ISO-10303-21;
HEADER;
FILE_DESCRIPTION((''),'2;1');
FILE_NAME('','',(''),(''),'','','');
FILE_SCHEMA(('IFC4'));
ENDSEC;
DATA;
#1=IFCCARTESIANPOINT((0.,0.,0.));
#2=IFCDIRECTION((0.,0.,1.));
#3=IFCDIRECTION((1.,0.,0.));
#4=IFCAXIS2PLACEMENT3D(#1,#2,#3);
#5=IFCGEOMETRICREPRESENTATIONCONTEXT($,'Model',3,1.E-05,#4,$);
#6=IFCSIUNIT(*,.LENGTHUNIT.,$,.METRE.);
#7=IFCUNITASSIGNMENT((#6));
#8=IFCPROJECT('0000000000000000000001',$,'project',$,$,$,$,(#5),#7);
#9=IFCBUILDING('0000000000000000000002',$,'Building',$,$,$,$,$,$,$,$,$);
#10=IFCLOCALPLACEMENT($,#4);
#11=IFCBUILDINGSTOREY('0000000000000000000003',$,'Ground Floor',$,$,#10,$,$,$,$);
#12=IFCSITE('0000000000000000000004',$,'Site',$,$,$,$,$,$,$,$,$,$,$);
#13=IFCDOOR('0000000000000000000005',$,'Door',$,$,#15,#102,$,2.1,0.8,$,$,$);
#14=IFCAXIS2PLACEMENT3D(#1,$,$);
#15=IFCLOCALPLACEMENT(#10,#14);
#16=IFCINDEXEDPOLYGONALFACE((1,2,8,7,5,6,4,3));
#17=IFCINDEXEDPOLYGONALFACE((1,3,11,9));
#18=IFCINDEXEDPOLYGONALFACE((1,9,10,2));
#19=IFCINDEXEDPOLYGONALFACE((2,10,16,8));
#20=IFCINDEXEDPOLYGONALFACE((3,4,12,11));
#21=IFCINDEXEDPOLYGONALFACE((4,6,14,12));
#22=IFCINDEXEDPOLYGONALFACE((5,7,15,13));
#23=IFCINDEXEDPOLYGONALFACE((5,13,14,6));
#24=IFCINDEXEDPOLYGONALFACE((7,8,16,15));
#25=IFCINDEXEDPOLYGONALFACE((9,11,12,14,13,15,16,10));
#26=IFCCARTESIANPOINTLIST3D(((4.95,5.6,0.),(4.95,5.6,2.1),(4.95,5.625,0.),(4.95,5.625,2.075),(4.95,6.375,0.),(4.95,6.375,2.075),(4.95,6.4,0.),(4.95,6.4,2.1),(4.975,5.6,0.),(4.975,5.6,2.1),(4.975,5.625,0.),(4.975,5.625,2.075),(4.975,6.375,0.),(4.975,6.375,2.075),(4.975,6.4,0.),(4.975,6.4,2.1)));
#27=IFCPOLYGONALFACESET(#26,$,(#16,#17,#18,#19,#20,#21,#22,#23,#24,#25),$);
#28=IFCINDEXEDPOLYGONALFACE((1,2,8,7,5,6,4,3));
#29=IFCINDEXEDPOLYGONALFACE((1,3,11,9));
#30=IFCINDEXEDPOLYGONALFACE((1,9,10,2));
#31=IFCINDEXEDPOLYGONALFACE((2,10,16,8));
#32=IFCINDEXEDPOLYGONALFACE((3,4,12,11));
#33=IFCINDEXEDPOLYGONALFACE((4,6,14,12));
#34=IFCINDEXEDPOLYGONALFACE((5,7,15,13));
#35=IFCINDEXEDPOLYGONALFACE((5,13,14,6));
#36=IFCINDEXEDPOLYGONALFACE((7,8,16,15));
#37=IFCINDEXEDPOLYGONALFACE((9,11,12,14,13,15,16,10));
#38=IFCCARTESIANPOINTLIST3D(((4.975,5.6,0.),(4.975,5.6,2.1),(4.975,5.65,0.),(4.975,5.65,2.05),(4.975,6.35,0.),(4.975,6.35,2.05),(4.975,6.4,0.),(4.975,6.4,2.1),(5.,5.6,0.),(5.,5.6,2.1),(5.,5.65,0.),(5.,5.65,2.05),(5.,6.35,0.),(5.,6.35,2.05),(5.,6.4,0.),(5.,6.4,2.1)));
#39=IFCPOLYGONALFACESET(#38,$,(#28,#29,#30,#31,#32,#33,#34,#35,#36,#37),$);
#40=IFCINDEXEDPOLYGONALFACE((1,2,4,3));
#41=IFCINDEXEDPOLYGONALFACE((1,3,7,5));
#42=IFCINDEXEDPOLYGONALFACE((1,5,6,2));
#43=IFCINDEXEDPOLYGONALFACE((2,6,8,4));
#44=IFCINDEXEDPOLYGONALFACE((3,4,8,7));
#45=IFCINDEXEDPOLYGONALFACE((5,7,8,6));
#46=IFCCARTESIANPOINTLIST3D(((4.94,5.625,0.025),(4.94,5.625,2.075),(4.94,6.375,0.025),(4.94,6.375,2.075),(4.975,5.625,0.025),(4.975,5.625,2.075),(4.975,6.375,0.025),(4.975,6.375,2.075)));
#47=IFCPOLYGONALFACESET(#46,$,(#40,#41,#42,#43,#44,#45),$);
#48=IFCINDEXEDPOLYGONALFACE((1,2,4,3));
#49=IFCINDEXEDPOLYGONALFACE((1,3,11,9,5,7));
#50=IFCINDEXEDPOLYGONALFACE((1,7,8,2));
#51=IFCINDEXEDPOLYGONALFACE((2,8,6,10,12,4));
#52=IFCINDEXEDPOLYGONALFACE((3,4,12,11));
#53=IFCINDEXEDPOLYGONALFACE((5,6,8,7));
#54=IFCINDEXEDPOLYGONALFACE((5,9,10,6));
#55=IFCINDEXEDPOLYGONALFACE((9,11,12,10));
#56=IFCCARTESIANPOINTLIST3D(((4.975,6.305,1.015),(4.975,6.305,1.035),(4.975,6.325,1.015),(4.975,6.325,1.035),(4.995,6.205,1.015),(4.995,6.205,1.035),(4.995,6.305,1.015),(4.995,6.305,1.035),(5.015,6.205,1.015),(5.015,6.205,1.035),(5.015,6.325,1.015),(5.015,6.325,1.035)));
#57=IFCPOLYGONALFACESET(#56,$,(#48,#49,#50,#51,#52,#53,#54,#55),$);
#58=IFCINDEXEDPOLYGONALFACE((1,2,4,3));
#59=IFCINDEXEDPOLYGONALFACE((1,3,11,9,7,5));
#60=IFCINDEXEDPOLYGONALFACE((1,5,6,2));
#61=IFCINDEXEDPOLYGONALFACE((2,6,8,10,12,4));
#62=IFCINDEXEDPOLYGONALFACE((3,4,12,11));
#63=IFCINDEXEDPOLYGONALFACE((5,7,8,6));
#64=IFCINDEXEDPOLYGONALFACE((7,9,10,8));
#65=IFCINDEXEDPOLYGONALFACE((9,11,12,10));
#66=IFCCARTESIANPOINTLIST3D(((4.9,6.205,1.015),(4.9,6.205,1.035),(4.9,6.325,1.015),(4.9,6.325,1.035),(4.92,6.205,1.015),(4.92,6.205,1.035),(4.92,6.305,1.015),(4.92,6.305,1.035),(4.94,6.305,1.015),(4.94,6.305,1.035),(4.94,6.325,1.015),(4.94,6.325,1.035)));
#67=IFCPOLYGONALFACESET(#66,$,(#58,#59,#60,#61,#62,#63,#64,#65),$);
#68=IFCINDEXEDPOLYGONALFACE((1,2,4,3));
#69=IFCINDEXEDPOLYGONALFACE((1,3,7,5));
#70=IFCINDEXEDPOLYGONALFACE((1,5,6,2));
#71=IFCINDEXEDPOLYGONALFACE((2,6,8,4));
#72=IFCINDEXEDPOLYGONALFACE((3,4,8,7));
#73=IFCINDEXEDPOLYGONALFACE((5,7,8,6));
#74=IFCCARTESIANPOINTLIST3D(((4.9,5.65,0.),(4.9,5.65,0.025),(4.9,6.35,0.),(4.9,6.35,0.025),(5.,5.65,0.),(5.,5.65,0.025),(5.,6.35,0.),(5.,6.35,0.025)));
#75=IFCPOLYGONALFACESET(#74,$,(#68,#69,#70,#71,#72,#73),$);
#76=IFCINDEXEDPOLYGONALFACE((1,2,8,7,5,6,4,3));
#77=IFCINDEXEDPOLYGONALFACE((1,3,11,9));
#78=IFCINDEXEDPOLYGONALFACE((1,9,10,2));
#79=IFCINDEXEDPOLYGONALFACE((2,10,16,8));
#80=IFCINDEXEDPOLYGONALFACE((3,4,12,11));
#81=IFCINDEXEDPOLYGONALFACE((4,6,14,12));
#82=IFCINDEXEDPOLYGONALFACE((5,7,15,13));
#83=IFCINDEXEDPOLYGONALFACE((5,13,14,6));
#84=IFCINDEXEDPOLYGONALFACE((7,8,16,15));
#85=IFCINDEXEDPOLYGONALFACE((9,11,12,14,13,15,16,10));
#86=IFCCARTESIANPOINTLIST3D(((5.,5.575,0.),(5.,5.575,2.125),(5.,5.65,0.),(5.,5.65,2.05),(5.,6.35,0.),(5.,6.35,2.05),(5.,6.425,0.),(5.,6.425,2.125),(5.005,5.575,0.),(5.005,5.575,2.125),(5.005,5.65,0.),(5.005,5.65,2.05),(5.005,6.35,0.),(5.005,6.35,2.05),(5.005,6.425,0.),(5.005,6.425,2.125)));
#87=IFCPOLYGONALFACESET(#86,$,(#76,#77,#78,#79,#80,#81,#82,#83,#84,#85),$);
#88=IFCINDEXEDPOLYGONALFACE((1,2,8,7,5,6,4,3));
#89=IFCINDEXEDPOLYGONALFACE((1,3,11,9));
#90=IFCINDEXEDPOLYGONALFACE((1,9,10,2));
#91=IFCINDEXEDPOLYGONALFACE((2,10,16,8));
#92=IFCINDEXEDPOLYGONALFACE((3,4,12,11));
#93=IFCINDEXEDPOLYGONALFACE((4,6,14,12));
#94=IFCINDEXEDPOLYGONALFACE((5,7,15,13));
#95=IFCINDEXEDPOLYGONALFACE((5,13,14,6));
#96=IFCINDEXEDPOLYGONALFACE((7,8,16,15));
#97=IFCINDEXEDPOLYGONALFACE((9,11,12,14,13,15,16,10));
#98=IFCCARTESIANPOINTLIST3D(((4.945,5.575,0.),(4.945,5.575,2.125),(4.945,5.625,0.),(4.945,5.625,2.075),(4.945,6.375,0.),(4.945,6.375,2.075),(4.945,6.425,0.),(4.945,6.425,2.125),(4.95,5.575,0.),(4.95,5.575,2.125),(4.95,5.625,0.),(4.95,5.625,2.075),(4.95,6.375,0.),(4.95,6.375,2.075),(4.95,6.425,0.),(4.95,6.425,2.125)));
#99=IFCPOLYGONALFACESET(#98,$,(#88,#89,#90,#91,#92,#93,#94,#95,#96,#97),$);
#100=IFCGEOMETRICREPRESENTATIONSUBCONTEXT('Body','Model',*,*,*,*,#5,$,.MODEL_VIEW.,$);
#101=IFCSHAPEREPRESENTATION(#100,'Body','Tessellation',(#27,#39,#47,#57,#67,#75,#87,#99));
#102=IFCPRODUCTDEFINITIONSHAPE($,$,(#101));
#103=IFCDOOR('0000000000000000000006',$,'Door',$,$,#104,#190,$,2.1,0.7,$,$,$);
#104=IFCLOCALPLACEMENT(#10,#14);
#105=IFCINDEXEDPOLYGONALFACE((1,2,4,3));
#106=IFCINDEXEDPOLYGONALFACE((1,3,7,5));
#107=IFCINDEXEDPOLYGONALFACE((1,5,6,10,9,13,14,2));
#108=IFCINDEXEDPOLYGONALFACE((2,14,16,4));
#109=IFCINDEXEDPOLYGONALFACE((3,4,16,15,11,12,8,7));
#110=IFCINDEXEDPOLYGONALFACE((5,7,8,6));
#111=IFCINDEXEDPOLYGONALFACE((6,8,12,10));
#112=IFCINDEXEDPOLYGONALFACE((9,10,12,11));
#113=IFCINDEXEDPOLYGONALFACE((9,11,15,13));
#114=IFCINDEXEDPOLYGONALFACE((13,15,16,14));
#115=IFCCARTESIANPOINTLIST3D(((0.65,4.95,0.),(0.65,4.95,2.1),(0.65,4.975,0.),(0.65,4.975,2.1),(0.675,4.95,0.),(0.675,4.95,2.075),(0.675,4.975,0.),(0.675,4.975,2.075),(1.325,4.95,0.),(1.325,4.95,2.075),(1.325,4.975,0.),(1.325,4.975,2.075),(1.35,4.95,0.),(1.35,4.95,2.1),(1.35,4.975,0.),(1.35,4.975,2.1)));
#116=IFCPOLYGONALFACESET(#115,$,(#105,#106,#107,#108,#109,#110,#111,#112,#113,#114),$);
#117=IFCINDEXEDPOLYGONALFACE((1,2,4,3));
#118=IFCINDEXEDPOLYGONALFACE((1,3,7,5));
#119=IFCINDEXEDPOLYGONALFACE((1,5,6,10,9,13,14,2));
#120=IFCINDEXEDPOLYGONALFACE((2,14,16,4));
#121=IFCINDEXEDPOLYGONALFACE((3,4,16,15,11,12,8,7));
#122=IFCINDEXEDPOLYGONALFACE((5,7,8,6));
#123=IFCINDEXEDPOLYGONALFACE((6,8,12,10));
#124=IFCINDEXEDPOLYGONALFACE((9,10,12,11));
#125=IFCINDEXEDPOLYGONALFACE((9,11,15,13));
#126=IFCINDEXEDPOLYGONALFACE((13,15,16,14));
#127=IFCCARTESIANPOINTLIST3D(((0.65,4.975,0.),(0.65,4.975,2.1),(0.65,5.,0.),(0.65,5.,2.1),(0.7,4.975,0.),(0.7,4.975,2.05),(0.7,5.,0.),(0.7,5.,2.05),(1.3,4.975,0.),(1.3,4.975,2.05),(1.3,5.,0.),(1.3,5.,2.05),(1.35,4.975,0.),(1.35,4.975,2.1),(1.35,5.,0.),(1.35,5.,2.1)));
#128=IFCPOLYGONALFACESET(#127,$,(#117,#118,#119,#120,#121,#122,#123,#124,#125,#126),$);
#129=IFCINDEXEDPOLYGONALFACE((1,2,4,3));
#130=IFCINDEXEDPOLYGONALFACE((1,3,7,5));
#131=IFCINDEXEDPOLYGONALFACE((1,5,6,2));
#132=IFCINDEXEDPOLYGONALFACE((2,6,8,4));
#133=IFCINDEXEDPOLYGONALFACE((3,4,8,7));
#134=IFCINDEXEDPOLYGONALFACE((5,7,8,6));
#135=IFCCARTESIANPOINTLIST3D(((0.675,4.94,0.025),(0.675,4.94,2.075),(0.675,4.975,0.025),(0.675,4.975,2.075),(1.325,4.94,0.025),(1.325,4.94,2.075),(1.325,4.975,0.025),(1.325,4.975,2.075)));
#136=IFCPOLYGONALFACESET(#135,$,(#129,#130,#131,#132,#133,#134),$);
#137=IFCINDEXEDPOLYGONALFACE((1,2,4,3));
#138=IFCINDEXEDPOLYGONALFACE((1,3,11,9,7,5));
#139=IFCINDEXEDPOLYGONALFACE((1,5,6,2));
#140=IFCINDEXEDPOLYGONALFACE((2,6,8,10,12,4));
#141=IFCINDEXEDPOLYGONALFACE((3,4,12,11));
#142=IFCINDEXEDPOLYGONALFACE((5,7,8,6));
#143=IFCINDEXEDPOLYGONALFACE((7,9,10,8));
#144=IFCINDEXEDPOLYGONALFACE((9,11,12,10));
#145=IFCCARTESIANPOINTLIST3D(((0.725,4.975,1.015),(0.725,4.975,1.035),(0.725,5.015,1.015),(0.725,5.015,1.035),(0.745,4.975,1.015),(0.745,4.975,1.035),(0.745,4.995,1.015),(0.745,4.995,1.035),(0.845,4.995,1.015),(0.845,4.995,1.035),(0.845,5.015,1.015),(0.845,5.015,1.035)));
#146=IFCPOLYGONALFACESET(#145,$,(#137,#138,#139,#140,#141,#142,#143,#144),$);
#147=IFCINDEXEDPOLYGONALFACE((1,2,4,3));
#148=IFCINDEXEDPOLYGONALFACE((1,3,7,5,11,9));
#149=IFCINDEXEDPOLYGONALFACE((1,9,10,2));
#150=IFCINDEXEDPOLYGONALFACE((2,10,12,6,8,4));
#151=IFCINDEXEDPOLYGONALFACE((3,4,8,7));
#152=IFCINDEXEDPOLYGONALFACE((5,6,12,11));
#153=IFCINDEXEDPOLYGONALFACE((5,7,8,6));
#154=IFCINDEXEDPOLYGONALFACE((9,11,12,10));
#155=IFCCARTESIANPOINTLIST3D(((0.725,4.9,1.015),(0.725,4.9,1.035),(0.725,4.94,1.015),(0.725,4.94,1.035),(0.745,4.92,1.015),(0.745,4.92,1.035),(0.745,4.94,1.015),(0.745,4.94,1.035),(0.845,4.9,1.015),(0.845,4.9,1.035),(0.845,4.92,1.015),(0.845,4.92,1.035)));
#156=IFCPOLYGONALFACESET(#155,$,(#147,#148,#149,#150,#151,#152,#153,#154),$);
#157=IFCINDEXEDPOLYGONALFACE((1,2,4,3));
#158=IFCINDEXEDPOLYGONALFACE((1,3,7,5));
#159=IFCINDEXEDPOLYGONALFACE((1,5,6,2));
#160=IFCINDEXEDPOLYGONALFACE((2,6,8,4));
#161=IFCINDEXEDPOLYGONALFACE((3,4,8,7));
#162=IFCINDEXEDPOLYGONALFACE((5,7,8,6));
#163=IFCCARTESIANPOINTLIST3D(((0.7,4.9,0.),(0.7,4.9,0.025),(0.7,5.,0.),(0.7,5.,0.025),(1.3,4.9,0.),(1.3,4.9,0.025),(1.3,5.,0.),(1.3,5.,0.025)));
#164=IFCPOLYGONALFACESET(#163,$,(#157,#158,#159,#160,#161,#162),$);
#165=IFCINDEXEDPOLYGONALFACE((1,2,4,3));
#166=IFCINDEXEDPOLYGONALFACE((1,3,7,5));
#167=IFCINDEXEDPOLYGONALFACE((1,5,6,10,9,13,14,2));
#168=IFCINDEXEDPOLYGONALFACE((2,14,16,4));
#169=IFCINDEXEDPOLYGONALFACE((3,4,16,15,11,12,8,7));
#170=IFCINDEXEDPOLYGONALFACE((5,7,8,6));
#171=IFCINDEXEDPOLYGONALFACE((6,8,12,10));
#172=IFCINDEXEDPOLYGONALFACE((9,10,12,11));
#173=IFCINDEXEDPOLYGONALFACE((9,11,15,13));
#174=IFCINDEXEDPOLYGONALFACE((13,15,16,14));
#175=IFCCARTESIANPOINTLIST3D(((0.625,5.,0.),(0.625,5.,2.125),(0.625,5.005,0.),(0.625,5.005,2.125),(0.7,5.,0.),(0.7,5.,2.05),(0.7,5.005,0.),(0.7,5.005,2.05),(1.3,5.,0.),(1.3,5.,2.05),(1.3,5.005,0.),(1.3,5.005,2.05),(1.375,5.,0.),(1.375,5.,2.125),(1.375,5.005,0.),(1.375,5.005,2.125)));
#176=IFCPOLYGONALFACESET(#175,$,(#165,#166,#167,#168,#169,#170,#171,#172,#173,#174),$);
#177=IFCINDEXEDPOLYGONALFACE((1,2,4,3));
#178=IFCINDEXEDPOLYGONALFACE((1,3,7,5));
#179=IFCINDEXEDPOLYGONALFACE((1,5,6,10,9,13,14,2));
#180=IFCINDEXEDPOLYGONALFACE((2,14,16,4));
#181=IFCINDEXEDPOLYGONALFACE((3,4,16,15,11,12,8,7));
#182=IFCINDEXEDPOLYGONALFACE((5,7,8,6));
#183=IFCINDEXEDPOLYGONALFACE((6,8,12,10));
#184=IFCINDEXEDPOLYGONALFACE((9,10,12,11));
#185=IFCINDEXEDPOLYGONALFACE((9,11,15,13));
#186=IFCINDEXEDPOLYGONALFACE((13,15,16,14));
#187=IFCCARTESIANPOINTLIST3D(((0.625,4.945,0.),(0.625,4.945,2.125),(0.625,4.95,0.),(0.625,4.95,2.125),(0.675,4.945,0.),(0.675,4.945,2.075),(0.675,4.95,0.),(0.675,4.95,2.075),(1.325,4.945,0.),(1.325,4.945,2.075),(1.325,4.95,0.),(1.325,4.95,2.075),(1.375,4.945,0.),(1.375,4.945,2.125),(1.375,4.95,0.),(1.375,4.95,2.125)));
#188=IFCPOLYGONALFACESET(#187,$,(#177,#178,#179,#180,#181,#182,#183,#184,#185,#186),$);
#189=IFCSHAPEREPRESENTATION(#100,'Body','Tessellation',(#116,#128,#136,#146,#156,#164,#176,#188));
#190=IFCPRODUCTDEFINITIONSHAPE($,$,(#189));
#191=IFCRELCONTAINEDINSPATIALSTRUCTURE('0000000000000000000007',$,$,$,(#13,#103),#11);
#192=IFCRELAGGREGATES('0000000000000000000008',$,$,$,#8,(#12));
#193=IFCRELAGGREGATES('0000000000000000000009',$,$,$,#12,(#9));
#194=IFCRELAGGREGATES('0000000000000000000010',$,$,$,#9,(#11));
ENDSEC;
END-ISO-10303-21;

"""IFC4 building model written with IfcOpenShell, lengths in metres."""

from ifc_helpers import new_model, si_unit, frame, origin_with_axes, place, context, subcontext, project, spatial, line, indexed_curve, outline, extrude, element, save


model = new_model("IFC4")

# Units and contexts
model_context = context("Model", 3, precision=1e-05, world=origin_with_axes())
body_context = subcontext(model_context, "Body", "Model", "MODEL_VIEW")
ifc_project = project(units=[si_unit("LENGTHUNIT", "METRE")], contexts=[model_context])

# Site, building, storey
site = spatial("IfcSite", under=ifc_project, Name="Site")
building = spatial("IfcBuilding", under=site, Name="Building")
storey_placement = place(None, origin_with_axes())
storey = spatial("IfcBuildingStorey", under=building, at=storey_placement, Name="Ground Floor")

# Doors
door_1_placement = place(storey_placement, frame((5.0, 5.6, 0.0), z_axis=(0.0, 0.0, 1.0), x_axis=(0.0, 1.0, 0.0)))
element("IfcDoor", 1, at=door_1_placement, inside=storey, Name="Door", OverallHeight=2.1, OverallWidth=0.8, context=body_context, shape_type="SweptSolid", body=[
    extrude(outline(indexed_curve([(0.0, 0.0), (0.0, 2.1), (0.8, 2.1), (0.8, 0.0), (0.775, 0.0), (0.775, 2.075), (0.025, 2.075), (0.025, 0.0)], segments=[line(1, 2, 3, 4, 5, 6, 7, 8, 1)])), frame((0.0, 0.025, 0.0), z_axis=(0.0, -1.0, 0.0), x_axis=(1.0, 0.0, 0.0)), (0.0, 0.0, -1.0), 0.025),
    extrude(outline(indexed_curve([(0.0, 0.0), (0.0, 2.1), (0.8, 2.1), (0.8, 0.0), (0.75, 0.0), (0.75, 2.05), (0.05, 2.05), (0.05, 0.0)], segments=[line(1, 2, 3, 4, 5, 6, 7, 8, 1)])), frame((0.0, 0.0, 0.0), z_axis=(0.0, -1.0, 0.0), x_axis=(1.0, 0.0, 0.0)), (0.0, 0.0, -1.0), 0.025),
    extrude(outline(indexed_curve([(0.0, 0.0), (0.75, 0.0), (0.75, 0.035), (0.0, 0.035)], segments=[line(1, 2, 3, 4, 1)])), frame((0.025, 0.025, 0.025), z_axis=(0.0, 0.0, 1.0), x_axis=(1.0, 0.0, 0.0)), (0.0, 0.0, 1.0), 2.05),
    extrude(outline(indexed_curve([(0.0, 0.0), (0.0, -0.04), (-0.12, -0.04), (-0.12, -0.02), (-0.02, -0.02), (-0.02, 0.0)], segments=[line(1, 2, 3, 4, 5, 6, 1)])), frame((0.725, 0.025, 1.015), z_axis=(0.0, 0.0, 1.0), x_axis=(1.0, 0.0, 0.0)), (0.0, 0.0, 1.0), 0.02),
    extrude(outline(indexed_curve([(0.0, 0.0), (0.0, 0.04), (-0.12, 0.04), (-0.12, 0.02), (-0.02, 0.02), (-0.02, 0.0)], segments=[line(1, 2, 3, 4, 5, 6, 1)])), frame((0.725, 0.06, 1.015), z_axis=(0.0, 0.0, 1.0), x_axis=(1.0, 0.0, 0.0)), (0.0, 0.0, 1.0), 0.02),
    extrude(outline(indexed_curve([(0.0, 0.0), (0.7, 0.0), (0.7, 0.1), (0.0, 0.1)], segments=[line(1, 2, 3, 4, 1)])), frame((0.05, 0.0, 0.0), z_axis=(0.0, 0.0, 1.0), x_axis=(1.0, 0.0, 0.0)), (0.0, 0.0, 1.0), 0.025),
    extrude(outline(indexed_curve([(0.0, 0.0), (0.0, 2.125), (0.85, 2.125), (0.85, 0.0), (0.775, 0.0), (0.775, 2.05), (0.075, 2.05), (0.075, 0.0)], segments=[line(1, 2, 3, 4, 5, 6, 7, 8, 1)])), frame((-0.025, -0.005, 0.0), z_axis=(0.0, -1.0, 0.0), x_axis=(1.0, 0.0, 0.0)), (0.0, 0.0, -1.0), 0.005),
    extrude(outline(indexed_curve([(0.0, 0.0), (0.0, 2.125), (0.85, 2.125), (0.85, 0.0), (0.8, 0.0), (0.8, 2.075), (0.05, 2.075), (0.05, 0.0)], segments=[line(1, 2, 3, 4, 5, 6, 7, 8, 1)])), frame((-0.025, 0.05, 0.0), z_axis=(0.0, -1.0, 0.0), x_axis=(1.0, 0.0, 0.0)), (0.0, 0.0, -1.0), 0.005),
])
door_2_placement = place(storey_placement, frame((1.35, 5.0, 0.0), z_axis=(0.0, 0.0, 1.0), x_axis=(-1.0, 0.0, 0.0)))
element("IfcDoor", 2, at=door_2_placement, inside=storey, Name="Door", OverallHeight=2.1, OverallWidth=0.7, context=body_context, shape_type="SweptSolid", body=[
    extrude(outline(indexed_curve([(0.0, 0.0), (0.0, 2.1), (0.7, 2.1), (0.7, 0.0), (0.675, 0.0), (0.675, 2.075), (0.025, 2.075), (0.025, 0.0)], segments=[line(1, 2, 3, 4, 5, 6, 7, 8, 1)])), frame((0.0, 0.025, 0.0), z_axis=(0.0, -1.0, 0.0), x_axis=(1.0, 0.0, 0.0)), (0.0, 0.0, -1.0), 0.025),
    extrude(outline(indexed_curve([(0.0, 0.0), (0.0, 2.1), (0.7, 2.1), (0.7, 0.0), (0.65, 0.0), (0.65, 2.05), (0.05, 2.05), (0.05, 0.0)], segments=[line(1, 2, 3, 4, 5, 6, 7, 8, 1)])), frame((0.0, 0.0, 0.0), z_axis=(0.0, -1.0, 0.0), x_axis=(1.0, 0.0, 0.0)), (0.0, 0.0, -1.0), 0.025),
    extrude(outline(indexed_curve([(0.0, 0.0), (0.65, 0.0), (0.65, 0.035), (0.0, 0.035)], segments=[line(1, 2, 3, 4, 1)])), frame((0.025, 0.025, 0.025), z_axis=(0.0, 0.0, 1.0), x_axis=(1.0, 0.0, 0.0)), (0.0, 0.0, 1.0), 2.05),
    extrude(outline(indexed_curve([(0.0, 0.0), (0.0, -0.04), (-0.12, -0.04), (-0.12, -0.02), (-0.02, -0.02), (-0.02, 0.0)], segments=[line(1, 2, 3, 4, 5, 6, 1)])), frame((0.625, 0.025, 1.015), z_axis=(0.0, 0.0, 1.0), x_axis=(1.0, 0.0, 0.0)), (0.0, 0.0, 1.0), 0.02),
    extrude(outline(indexed_curve([(0.0, 0.0), (0.0, 0.04), (-0.12, 0.04), (-0.12, 0.02), (-0.02, 0.02), (-0.02, 0.0)], segments=[line(1, 2, 3, 4, 5, 6, 1)])), frame((0.625, 0.06, 1.015), z_axis=(0.0, 0.0, 1.0), x_axis=(1.0, 0.0, 0.0)), (0.0, 0.0, 1.0), 0.02),
    extrude(outline(indexed_curve([(0.0, 0.0), (0.6, 0.0), (0.6, 0.1), (0.0, 0.1)], segments=[line(1, 2, 3, 4, 1)])), frame((0.05, 0.0, 0.0), z_axis=(0.0, 0.0, 1.0), x_axis=(1.0, 0.0, 0.0)), (0.0, 0.0, 1.0), 0.025),
    extrude(outline(indexed_curve([(0.0, 0.0), (0.0, 2.125), (0.75, 2.125), (0.75, 0.0), (0.675, 0.0), (0.675, 2.05), (0.075, 2.05), (0.075, 0.0)], segments=[line(1, 2, 3, 4, 5, 6, 7, 8, 1)])), frame((-0.025, -0.005, 0.0), z_axis=(0.0, -1.0, 0.0), x_axis=(1.0, 0.0, 0.0)), (0.0, 0.0, -1.0), 0.005),
    extrude(outline(indexed_curve([(0.0, 0.0), (0.0, 2.125), (0.75, 2.125), (0.75, 0.0), (0.7, 0.0), (0.7, 2.075), (0.05, 2.075), (0.05, 0.0)], segments=[line(1, 2, 3, 4, 5, 6, 7, 8, 1)])), frame((-0.025, 0.05, 0.0), z_axis=(0.0, -1.0, 0.0), x_axis=(1.0, 0.0, 0.0)), (0.0, 0.0, -1.0), 0.005),
])

save(model, "model.ifc")
